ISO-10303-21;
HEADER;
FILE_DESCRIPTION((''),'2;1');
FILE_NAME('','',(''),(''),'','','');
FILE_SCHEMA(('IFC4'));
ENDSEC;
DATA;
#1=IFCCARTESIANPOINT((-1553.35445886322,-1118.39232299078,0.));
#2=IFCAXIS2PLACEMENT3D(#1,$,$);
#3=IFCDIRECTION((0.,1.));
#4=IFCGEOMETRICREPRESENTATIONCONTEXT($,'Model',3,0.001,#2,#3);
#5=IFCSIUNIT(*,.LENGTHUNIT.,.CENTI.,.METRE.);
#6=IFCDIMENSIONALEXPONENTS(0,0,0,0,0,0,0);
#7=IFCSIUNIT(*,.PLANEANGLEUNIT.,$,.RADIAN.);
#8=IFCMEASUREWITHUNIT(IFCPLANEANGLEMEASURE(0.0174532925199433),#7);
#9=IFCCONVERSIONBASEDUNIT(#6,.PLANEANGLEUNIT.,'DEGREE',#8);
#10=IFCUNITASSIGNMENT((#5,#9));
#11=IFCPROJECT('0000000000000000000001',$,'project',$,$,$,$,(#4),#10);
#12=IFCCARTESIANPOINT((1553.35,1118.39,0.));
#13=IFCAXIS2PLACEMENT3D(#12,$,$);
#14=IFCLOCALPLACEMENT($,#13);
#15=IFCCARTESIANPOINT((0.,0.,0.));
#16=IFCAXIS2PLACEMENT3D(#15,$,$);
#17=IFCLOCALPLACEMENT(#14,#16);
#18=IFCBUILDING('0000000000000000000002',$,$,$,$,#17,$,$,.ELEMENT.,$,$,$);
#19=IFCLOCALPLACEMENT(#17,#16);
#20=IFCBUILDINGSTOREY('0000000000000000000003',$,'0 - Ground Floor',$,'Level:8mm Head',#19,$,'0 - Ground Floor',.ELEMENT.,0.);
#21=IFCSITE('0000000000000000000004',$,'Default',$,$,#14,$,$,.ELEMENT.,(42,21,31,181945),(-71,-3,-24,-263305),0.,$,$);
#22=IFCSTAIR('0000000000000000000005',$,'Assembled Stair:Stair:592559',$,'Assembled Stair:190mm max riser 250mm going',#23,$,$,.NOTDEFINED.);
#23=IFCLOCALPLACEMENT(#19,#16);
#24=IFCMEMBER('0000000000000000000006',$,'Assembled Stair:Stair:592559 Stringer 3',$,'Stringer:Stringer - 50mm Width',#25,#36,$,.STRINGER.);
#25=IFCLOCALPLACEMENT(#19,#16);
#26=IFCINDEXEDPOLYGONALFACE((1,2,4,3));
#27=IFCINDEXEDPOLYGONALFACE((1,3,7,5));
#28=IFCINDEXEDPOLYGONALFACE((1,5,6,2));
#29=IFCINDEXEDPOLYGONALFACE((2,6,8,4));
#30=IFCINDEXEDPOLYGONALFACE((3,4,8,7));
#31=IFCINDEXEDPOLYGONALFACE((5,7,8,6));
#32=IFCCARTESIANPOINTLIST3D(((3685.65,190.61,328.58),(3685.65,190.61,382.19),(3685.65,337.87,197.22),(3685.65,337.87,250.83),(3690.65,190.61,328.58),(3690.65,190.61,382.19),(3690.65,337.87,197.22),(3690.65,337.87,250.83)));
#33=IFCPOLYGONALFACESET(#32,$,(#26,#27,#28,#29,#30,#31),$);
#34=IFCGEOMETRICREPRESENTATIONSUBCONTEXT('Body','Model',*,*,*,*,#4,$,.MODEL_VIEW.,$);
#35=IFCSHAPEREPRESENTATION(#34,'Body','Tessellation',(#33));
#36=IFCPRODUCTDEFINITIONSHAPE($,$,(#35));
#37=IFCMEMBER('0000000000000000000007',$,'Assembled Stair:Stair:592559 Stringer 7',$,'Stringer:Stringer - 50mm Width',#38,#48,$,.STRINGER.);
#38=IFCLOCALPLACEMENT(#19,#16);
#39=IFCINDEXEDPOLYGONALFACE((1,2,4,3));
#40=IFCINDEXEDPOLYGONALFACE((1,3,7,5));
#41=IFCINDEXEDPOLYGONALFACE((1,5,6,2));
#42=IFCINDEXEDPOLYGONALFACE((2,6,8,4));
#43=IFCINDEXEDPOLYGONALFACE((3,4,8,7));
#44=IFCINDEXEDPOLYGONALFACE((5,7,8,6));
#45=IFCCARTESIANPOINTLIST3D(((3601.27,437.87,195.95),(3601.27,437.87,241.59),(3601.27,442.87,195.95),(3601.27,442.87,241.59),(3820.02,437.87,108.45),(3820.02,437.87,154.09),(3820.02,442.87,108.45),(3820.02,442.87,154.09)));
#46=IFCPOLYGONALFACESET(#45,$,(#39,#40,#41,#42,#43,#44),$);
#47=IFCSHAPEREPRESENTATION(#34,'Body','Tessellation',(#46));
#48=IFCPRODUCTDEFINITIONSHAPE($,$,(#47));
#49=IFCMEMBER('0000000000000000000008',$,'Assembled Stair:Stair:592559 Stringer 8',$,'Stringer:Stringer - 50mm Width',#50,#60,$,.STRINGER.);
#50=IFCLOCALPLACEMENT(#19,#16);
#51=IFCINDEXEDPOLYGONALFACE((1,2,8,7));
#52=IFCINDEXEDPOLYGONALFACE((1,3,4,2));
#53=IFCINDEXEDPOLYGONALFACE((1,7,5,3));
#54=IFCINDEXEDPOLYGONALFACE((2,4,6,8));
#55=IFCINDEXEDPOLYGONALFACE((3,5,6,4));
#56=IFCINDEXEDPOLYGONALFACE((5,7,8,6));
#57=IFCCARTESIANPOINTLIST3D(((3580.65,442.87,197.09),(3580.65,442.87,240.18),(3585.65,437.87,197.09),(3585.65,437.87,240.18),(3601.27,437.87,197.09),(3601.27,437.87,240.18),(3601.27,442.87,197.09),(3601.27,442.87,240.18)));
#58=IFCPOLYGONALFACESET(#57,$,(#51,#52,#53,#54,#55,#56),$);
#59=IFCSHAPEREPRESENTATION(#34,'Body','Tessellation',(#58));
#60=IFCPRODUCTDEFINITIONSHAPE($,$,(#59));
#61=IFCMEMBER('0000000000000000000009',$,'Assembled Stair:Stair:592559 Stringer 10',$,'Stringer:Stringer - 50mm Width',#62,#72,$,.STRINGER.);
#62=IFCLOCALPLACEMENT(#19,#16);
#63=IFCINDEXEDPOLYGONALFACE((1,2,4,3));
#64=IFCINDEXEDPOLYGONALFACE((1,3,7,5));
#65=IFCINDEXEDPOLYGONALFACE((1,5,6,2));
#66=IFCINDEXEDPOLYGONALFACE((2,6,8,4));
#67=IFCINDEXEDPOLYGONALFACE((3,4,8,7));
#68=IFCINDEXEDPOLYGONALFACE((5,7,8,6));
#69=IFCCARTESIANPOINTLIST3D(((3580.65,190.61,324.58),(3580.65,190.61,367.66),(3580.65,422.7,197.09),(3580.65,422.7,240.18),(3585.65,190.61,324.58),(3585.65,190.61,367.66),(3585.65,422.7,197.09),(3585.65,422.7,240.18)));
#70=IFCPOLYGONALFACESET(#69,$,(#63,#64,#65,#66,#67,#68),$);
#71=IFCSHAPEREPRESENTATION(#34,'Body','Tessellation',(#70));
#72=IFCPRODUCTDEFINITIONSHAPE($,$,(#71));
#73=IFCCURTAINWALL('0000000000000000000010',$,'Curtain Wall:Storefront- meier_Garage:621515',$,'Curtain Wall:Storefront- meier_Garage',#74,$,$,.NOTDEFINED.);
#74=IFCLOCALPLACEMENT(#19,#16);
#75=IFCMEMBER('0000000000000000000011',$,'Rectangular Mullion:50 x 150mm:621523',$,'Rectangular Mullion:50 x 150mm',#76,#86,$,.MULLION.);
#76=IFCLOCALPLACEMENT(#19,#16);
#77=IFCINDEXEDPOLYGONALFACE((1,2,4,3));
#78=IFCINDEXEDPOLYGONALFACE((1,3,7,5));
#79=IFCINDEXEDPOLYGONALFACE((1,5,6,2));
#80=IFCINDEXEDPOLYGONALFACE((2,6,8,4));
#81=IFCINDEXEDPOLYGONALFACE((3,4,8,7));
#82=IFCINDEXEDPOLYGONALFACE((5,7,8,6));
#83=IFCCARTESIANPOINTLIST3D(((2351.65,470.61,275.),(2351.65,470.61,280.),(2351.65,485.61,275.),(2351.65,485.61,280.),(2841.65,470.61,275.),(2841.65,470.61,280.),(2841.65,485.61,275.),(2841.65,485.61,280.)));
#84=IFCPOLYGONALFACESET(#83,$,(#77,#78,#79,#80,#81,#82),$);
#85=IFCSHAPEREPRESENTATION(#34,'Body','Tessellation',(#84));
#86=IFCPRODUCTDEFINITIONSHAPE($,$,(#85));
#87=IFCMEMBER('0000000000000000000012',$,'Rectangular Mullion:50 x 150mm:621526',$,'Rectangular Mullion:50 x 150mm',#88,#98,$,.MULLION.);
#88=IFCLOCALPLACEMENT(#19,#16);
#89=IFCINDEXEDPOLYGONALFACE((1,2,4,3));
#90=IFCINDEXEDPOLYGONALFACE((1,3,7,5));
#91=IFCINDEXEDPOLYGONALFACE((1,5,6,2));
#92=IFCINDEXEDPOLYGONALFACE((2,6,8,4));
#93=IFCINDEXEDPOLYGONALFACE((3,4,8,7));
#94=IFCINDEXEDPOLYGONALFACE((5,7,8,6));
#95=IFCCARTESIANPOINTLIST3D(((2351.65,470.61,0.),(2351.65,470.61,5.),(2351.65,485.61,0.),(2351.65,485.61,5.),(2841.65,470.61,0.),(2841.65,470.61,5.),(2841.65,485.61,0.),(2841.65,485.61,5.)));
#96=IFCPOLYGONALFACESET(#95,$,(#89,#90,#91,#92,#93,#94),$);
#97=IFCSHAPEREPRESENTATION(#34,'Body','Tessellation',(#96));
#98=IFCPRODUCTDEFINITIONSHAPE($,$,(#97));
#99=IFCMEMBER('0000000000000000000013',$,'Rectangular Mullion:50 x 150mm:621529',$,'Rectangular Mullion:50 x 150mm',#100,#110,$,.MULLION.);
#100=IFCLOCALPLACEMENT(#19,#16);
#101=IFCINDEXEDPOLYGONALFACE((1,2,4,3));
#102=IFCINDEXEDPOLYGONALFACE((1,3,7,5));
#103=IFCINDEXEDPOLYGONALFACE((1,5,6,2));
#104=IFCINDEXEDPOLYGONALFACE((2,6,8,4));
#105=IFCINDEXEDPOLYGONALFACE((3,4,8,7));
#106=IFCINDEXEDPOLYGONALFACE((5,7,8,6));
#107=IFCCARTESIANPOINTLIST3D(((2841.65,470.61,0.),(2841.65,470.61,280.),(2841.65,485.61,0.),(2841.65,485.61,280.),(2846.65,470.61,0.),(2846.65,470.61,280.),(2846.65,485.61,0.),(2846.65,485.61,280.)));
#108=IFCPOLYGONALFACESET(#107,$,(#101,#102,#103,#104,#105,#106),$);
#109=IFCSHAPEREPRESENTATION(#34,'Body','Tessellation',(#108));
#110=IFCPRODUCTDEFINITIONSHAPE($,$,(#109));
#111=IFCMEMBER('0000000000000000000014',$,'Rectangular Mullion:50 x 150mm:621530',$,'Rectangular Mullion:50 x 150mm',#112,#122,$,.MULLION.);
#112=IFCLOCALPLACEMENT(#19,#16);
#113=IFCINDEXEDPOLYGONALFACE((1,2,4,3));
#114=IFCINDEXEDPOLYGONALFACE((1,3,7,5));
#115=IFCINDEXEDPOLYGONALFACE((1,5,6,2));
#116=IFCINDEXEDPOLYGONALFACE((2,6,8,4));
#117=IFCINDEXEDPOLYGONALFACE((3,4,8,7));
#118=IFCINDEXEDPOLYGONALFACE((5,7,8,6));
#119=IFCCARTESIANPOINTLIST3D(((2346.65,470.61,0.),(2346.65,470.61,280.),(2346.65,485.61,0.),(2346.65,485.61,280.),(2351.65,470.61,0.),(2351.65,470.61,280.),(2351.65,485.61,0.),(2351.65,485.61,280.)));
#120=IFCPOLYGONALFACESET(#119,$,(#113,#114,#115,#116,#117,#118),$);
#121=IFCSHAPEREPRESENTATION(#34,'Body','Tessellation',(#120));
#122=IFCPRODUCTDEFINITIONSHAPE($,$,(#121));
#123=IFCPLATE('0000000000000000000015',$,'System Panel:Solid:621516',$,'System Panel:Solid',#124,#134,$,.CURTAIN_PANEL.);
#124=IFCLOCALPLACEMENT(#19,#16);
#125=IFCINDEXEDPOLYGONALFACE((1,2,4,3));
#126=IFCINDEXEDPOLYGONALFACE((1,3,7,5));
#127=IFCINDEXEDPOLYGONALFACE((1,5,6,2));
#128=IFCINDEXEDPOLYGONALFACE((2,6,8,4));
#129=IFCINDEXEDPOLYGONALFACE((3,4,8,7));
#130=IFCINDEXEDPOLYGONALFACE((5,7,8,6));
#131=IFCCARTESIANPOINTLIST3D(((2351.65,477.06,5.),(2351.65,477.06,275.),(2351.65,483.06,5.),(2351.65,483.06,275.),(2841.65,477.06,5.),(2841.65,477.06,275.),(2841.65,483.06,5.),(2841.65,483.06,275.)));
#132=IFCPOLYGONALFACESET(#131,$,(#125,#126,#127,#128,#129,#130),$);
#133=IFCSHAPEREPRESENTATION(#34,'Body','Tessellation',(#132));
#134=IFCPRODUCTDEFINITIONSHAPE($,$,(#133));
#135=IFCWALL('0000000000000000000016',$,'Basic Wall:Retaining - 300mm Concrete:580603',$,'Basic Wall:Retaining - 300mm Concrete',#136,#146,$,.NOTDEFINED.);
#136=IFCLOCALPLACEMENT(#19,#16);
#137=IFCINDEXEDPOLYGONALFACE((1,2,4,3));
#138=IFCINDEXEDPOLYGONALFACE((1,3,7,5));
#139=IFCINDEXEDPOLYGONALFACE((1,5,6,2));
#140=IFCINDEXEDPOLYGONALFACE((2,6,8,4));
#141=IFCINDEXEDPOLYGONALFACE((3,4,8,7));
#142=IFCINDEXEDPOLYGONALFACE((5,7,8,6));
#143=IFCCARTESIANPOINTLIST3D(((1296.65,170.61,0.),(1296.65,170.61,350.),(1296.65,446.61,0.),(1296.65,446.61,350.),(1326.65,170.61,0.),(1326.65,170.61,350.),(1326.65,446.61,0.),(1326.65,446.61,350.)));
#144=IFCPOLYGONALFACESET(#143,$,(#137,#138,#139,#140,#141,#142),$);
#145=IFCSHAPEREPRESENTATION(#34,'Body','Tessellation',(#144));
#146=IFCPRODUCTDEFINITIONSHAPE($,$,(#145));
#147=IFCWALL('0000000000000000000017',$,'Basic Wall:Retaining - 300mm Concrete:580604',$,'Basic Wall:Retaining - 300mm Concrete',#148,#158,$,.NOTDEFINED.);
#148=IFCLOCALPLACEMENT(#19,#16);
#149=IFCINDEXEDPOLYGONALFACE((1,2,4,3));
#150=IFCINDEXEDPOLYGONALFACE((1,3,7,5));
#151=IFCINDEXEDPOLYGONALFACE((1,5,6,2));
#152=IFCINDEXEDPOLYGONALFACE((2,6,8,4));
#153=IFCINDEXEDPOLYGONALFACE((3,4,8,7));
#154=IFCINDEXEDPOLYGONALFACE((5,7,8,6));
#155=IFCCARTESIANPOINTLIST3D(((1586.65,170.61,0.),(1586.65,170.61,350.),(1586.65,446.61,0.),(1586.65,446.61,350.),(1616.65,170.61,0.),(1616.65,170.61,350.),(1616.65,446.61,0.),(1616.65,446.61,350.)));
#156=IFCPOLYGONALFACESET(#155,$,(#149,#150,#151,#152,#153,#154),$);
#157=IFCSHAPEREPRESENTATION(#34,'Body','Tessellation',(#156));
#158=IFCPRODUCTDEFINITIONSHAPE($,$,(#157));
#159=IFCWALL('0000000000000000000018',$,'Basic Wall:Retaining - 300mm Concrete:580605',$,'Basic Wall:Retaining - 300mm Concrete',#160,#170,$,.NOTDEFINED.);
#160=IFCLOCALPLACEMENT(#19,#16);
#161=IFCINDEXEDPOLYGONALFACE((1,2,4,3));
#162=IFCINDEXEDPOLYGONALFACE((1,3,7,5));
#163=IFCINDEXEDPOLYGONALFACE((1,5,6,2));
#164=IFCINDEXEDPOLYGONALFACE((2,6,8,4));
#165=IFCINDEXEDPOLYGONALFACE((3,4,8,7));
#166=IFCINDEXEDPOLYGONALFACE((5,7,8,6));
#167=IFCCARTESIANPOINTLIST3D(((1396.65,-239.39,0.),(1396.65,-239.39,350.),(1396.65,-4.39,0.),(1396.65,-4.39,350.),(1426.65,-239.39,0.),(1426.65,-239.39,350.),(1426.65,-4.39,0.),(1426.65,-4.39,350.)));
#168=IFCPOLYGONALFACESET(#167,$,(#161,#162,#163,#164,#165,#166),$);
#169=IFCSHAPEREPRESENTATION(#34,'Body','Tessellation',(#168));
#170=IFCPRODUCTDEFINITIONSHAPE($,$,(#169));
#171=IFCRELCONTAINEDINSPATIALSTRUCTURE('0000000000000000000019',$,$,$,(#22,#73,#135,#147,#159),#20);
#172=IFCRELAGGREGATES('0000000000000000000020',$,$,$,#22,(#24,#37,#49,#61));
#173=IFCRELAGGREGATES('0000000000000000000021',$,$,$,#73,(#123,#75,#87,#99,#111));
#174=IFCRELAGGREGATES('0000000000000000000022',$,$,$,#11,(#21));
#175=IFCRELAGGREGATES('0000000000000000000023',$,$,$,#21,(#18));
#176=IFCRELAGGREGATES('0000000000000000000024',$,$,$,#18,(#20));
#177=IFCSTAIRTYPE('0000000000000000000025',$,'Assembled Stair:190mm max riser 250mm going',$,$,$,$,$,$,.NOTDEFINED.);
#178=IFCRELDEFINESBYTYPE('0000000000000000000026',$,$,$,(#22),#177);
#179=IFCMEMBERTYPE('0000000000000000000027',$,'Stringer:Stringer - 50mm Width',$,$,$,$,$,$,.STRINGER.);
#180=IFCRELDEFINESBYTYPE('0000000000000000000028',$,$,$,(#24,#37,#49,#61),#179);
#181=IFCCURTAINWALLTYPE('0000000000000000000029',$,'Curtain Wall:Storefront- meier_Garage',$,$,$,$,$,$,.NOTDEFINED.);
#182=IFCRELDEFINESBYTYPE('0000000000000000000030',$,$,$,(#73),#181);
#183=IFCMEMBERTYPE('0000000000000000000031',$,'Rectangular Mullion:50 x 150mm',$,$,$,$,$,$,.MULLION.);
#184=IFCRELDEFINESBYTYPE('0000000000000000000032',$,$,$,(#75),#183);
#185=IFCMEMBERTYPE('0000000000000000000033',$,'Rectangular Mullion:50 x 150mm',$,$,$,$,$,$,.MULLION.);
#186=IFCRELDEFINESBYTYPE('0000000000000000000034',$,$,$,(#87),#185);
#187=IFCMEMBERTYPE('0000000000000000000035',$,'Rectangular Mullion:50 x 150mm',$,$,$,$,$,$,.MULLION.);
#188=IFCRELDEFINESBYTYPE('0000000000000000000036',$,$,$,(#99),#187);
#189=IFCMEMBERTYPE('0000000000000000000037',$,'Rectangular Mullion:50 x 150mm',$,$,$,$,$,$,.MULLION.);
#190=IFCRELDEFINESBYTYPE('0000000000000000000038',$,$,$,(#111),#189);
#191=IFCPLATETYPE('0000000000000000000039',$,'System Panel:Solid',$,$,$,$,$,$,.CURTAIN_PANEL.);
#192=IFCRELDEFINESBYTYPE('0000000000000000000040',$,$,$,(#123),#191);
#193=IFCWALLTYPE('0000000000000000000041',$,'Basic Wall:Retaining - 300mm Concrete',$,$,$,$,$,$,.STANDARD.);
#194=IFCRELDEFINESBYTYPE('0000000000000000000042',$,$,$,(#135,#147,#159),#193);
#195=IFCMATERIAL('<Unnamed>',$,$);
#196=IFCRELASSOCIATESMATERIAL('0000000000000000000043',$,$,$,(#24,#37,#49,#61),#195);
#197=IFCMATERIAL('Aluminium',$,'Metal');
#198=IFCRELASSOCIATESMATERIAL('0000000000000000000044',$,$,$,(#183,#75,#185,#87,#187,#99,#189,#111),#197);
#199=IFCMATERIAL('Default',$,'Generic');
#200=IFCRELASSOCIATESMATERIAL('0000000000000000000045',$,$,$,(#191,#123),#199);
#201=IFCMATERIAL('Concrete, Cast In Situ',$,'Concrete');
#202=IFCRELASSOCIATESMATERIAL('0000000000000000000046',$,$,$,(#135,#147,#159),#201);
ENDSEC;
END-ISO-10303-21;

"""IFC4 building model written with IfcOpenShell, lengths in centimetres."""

from ifc_helpers import new_model, entity, si_unit, converted_unit, direction, frame, origin, place, context, subcontext, project, spatial, indexed_curve, outline, extrude, source, transform, mapped, material, type_object, type_shapes, element, aggregate, save


model = new_model("IFC4")

# Units and contexts
model_context = context("Model", 3, precision=0.001, world=frame((-1553.35445886322, -1118.39232299078, 0.0)), true_north=direction((0.0, 1.0)))
body_context = subcontext(model_context, "Body", "Model", "MODEL_VIEW")
ifc_project = project(units=[si_unit("LENGTHUNIT", "METRE", prefix="CENTI"), converted_unit("PLANEANGLEUNIT", "DEGREE", entity("IfcPlaneAngleMeasure", 0.0174532925199433), si_unit("PLANEANGLEUNIT", "RADIAN"), dimensions=[0, 0, 0, 0, 0, 0, 0])], contexts=[model_context])

# Site, building, storey
site_placement = place(None, frame((1553.35, 1118.39, 0.0)))
site = spatial("IfcSite", under=ifc_project, at=site_placement, Name="Default", CompositionType="ELEMENT", RefLatitude=(42, 21, 31, 181945), RefLongitude=(-71, -3, -24, -263305), RefElevation=0.0)
building_placement = place(site_placement, origin())
building = spatial("IfcBuilding", under=site, at=building_placement, CompositionType="ELEMENT")
storey_placement = place(building_placement, origin())
storey = spatial("IfcBuildingStorey", under=building, at=storey_placement, Name="0 - Ground Floor", ObjectType="Level:8mm Head", LongName="0 - Ground Floor", CompositionType="ELEMENT", Elevation=0.0)

# Stair, members
stair_type = type_object("IfcStairType", Name="Assembled Stair:190mm max riser 250mm going", PredefinedType="NOTDEFINED")
stair_placement = place(storey_placement, origin())
stair = element("IfcStair", 1, at=stair_placement, inside=storey, type_object=stair_type, Name="Assembled Stair:Stair:592559", ObjectType="Assembled Stair:190mm max riser 250mm going", PredefinedType="NOTDEFINED")
ifc_material_1 = material(Name="<Unnamed>")
member_type_1 = type_object("IfcMemberType", Name="Stringer:Stringer - 50mm Width", PredefinedType="STRINGER")
member_1_placement = place(stair_placement, origin())
member_1 = element("IfcMember", 2, at=member_1_placement, type_object=member_type_1, material=ifc_material_1, Name="Assembled Stair:Stair:592559 Stringer 3", ObjectType="Stringer:Stringer - 50mm Width", PredefinedType="STRINGER", context=body_context, shape_type="SweptSolid", body=[
    extrude(outline(indexed_curve([(-80.83, -20.0), (116.51, -20.0), (80.83, 20.0), (-116.51, 20.0), (-80.83, -20.0)], self_intersect=False)), frame((3685.65, 264.24, 289.71), z_axis=(1.0, 0.0, 0.0), x_axis=(0.0, -0.746258, 0.665657)), (0.0, 0.0, 1.0), 5.0),
])
member_2_placement = place(stair_placement, origin())
member_2 = element("IfcMember", 3, at=member_2_placement, type_object=member_type_1, material=ifc_material_1, Name="Assembled Stair:Stair:592559 Stringer 7", ObjectType="Stringer:Stringer - 50mm Width", PredefinedType="STRINGER", context=body_context, shape_type="SweptSolid", body=[
    extrude(outline(indexed_curve([(-126.28, -21.19), (109.33, -21.19), (126.28, 21.19), (-109.33, 21.19), (-126.28, -21.19)], self_intersect=False)), frame((3710.65, 437.87, 175.02), z_axis=(0.0, 1.0, 0.0), x_axis=(-0.928478, 0.0, 0.371387)), (0.0, 0.0, 1.0), 5.0),
])
member_3_placement = place(stair_placement, origin())
member_3 = element("IfcMember", 4, at=member_3_placement, type_object=member_type_1, material=ifc_material_1, Name="Assembled Stair:Stair:592559 Stringer 8", ObjectType="Stringer:Stringer - 50mm Width", PredefinedType="STRINGER", context=body_context, shape_type="SweptSolid", body=[
    extrude(outline(indexed_curve([(-9.06, -2.5), (11.56, -2.5), (6.56, 2.5), (-9.06, 2.5), (-9.06, -2.5)], self_intersect=False)), frame((3592.21, 440.37, 197.09), z_axis=(0.0, 0.0, 1.0), x_axis=(-1.0, 0.0, 0.0)), (0.0, 0.0, 1.0), 43.08),
])
member_4_placement = place(stair_placement, origin())
member_4 = element("IfcMember", 5, at=member_4_placement, type_object=member_type_1, material=ifc_material_1, Name="Assembled Stair:Stair:592559 Stringer 10", ObjectType="Stringer:Stringer - 50mm Width", PredefinedType="STRINGER", context=body_context, shape_type="SweptSolid", body=[
    extrude(outline(indexed_curve([(-122.03, -18.88), (142.77, -18.88), (122.03, 18.88), (-142.77, 18.88), (-122.03, -18.88)], self_intersect=False)), frame((3580.65, 306.65, 282.38), z_axis=(1.0, 0.0, 0.0), x_axis=(0.0, -0.876487, 0.481425)), (0.0, 0.0, 1.0), 5.0),
])
aggregate(stair, [member_1, member_2, member_3, member_4])

# Curtain wall, members, plate
curtain_wall_type = type_object("IfcCurtainWallType", Name="Curtain Wall:Storefront- meier_Garage", PredefinedType="NOTDEFINED")
curtain_wall_placement = place(storey_placement, origin())
curtain_wall = element("IfcCurtainWall", 6, at=curtain_wall_placement, inside=storey, type_object=curtain_wall_type, Name="Curtain Wall:Storefront- meier_Garage:621515", ObjectType="Curtain Wall:Storefront- meier_Garage", PredefinedType="NOTDEFINED")
ifc_material_2 = material(Name="Aluminium", Category="Metal")
member_type_2 = type_object("IfcMemberType", Name="Rectangular Mullion:50 x 150mm", PredefinedType="MULLION", material=ifc_material_2)
shared_shape_1 = source(origin(), body_context, "Body", "SweptSolid", [
    extrude(outline(indexed_curve([(-2.5, -7.5), (2.5, -7.5), (2.5, 7.5), (-2.5, 7.5), (-2.5, -7.5)], self_intersect=False)), frame((-2.5, 0.0, -490.0), z_axis=(0.0, 0.0, 1.0), x_axis=(-1.0, 0.0, 0.0)), (0.0, 0.0, 1.0), 490.0),
])
type_shapes(member_type_2, [shared_shape_1])
member_5_placement = place(curtain_wall_placement, frame((2841.65, 478.11, 280.0), z_axis=(1.0, 0.0, 0.0), x_axis=(0.0, 0.0, 1.0)))
member_5 = element("IfcMember", 7, at=member_5_placement, type_object=member_type_2, material=ifc_material_2, Name="Rectangular Mullion:50 x 150mm:621523", ObjectType="Rectangular Mullion:50 x 150mm", PredefinedType="MULLION", context=body_context, shape_type="MappedRepresentation", body=[
    mapped(shared_shape_1, transform((0.0, 0.0, 0.0), scale=1.0)),
])
member_type_3 = type_object("IfcMemberType", Name="Rectangular Mullion:50 x 150mm", PredefinedType="MULLION", material=ifc_material_2)
shared_shape_2 = source(origin(), body_context, "Body", "SweptSolid", [
    extrude(outline(indexed_curve([(-2.5, -7.5), (2.5, -7.5), (2.5, 7.5), (-2.5, 7.5), (-2.5, -7.5)], self_intersect=False)), frame((-2.5, 0.0, -490.0), z_axis=(0.0, 0.0, 1.0), x_axis=(-1.0, 0.0, 0.0)), (0.0, 0.0, 1.0), 490.0),
])
type_shapes(member_type_3, [shared_shape_2])
member_6_placement = place(curtain_wall_placement, frame((2351.65, 478.11, 0.0), z_axis=(-1.0, 0.0, 0.0), x_axis=(0.0, 0.0, -1.0)))
member_6 = element("IfcMember", 8, at=member_6_placement, type_object=member_type_3, material=ifc_material_2, Name="Rectangular Mullion:50 x 150mm:621526", ObjectType="Rectangular Mullion:50 x 150mm", PredefinedType="MULLION", context=body_context, shape_type="MappedRepresentation", body=[
    mapped(shared_shape_2, transform((0.0, 0.0, 0.0), scale=1.0)),
])
member_type_4 = type_object("IfcMemberType", Name="Rectangular Mullion:50 x 150mm", PredefinedType="MULLION", material=ifc_material_2)
shared_shape_3 = source(origin(), body_context, "Body", "SweptSolid", [
    extrude(outline(indexed_curve([(-2.5, -7.5), (2.5, -7.5), (2.5, 7.5), (-2.5, 7.5), (-2.5, -7.5)], self_intersect=False)), frame((-2.5, 0.0, -280.0), z_axis=(0.0, 0.0, 1.0), x_axis=(-1.0, 0.0, 0.0)), (0.0, 0.0, 1.0), 280.0),
])
type_shapes(member_type_4, [shared_shape_3])
member_7_placement = place(curtain_wall_placement, frame((2846.65, 478.11, 0.0), z_axis=(0.0, 0.0, -1.0), x_axis=(1.0, 0.0, 0.0)))
member_7 = element("IfcMember", 9, at=member_7_placement, type_object=member_type_4, material=ifc_material_2, Name="Rectangular Mullion:50 x 150mm:621529", ObjectType="Rectangular Mullion:50 x 150mm", PredefinedType="MULLION", context=body_context, shape_type="MappedRepresentation", body=[
    mapped(shared_shape_3, transform((0.0, 0.0, 0.0), scale=1.0)),
])
member_type_5 = type_object("IfcMemberType", Name="Rectangular Mullion:50 x 150mm", PredefinedType="MULLION", material=ifc_material_2)
shared_shape_4 = source(origin(), body_context, "Body", "SweptSolid", [
    extrude(outline(indexed_curve([(-2.5, -7.5), (2.5, -7.5), (2.5, 7.5), (-2.5, 7.5), (-2.5, -7.5)], self_intersect=False)), frame((-2.5, 0.0, -280.0), z_axis=(0.0, 0.0, 1.0), x_axis=(-1.0, 0.0, 0.0)), (0.0, 0.0, 1.0), 280.0),
])
type_shapes(member_type_5, [shared_shape_4])
member_8_placement = place(curtain_wall_placement, frame((2346.65, 478.11, 280.0), z_axis=(0.0, 0.0, 1.0), x_axis=(-1.0, 0.0, 0.0)))
member_8 = element("IfcMember", 10, at=member_8_placement, type_object=member_type_5, material=ifc_material_2, Name="Rectangular Mullion:50 x 150mm:621530", ObjectType="Rectangular Mullion:50 x 150mm", PredefinedType="MULLION", context=body_context, shape_type="MappedRepresentation", body=[
    mapped(shared_shape_4, transform((0.0, 0.0, 0.0), scale=1.0)),
])
ifc_material_3 = material(Name="Default", Category="Generic")
plate_type = type_object("IfcPlateType", Name="System Panel:Solid", PredefinedType="CURTAIN_PANEL", material=ifc_material_3)
shared_shape_5 = source(origin(), body_context, "Body", "SweptSolid", [
    extrude(outline(indexed_curve([(-3.0, -245.0), (3.0, -245.0), (3.0, 245.0), (-3.0, 245.0), (-3.0, -245.0)], self_intersect=False)), frame((0.0, 1.95, 0.0), z_axis=(0.0, 0.0, 1.0), x_axis=(0.0, 1.0, 0.0)), (0.0, 0.0, 1.0), 270.0),
])
type_shapes(plate_type, [shared_shape_5])
plate_placement = place(curtain_wall_placement, frame((2596.65, 478.11, 5.0)))
plate = element("IfcPlate", 11, at=plate_placement, type_object=plate_type, material=ifc_material_3, Name="System Panel:Solid:621516", ObjectType="System Panel:Solid", PredefinedType="CURTAIN_PANEL", context=body_context, shape_type="MappedRepresentation", body=[
    mapped(shared_shape_5, transform((0.0, 0.0, 0.0), scale=1.0)),
])
aggregate(curtain_wall, [plate, member_5, member_6, member_7, member_8])

# Walls
ifc_material_4 = material(Name="Concrete, Cast In Situ", Category="Concrete")
wall_type_1 = type_object("IfcWallType", Name="Basic Wall:Retaining - 300mm Concrete", PredefinedType="STANDARD")
for number, where, z_axis, x_axis, name in (
    (12, (1311.65, 446.61, 0.0), (0.0, 0.0, 1.0), (0.0, -1.0, 0.0), "Basic Wall:Retaining - 300mm Concrete:580603"),
    (13, (1601.65, 446.61, 0.0), (0.0, 0.0, 1.0), (0.0, -1.0, 0.0), "Basic Wall:Retaining - 300mm Concrete:580604"),
):
    element("IfcWall", number, at=place(storey_placement, frame(where, z_axis=z_axis, x_axis=x_axis)), inside=storey, type_object=wall_type_1, material=ifc_material_4, Name=name, ObjectType="Basic Wall:Retaining - 300mm Concrete", PredefinedType="NOTDEFINED", context=body_context, shape_type="SweptSolid", body=[
        extrude(outline(indexed_curve([(276.0, 15.0), (0.0, 15.0), (0.0, -15.0), (276.0, -15.0), (276.0, 15.0)], self_intersect=False)), origin(), (0.0, 0.0, 1.0), 350.0),
    ])
wall_1_placement = place(storey_placement, frame((1411.65, -4.39, 0.0), z_axis=(0.0, 0.0, 1.0), x_axis=(0.0, -1.0, 0.0)))
element("IfcWall", 14, at=wall_1_placement, inside=storey, type_object=wall_type_1, material=ifc_material_4, Name="Basic Wall:Retaining - 300mm Concrete:580605", ObjectType="Basic Wall:Retaining - 300mm Concrete", PredefinedType="NOTDEFINED", context=body_context, shape_type="SweptSolid", body=[
    extrude(outline(indexed_curve([(235.0, 15.0), (0.0, 15.0), (0.0, -15.0), (235.0, -15.0), (235.0, 15.0)], self_intersect=False)), origin(), (0.0, 0.0, 1.0), 350.0),
])

save(model, "model.ifc")
